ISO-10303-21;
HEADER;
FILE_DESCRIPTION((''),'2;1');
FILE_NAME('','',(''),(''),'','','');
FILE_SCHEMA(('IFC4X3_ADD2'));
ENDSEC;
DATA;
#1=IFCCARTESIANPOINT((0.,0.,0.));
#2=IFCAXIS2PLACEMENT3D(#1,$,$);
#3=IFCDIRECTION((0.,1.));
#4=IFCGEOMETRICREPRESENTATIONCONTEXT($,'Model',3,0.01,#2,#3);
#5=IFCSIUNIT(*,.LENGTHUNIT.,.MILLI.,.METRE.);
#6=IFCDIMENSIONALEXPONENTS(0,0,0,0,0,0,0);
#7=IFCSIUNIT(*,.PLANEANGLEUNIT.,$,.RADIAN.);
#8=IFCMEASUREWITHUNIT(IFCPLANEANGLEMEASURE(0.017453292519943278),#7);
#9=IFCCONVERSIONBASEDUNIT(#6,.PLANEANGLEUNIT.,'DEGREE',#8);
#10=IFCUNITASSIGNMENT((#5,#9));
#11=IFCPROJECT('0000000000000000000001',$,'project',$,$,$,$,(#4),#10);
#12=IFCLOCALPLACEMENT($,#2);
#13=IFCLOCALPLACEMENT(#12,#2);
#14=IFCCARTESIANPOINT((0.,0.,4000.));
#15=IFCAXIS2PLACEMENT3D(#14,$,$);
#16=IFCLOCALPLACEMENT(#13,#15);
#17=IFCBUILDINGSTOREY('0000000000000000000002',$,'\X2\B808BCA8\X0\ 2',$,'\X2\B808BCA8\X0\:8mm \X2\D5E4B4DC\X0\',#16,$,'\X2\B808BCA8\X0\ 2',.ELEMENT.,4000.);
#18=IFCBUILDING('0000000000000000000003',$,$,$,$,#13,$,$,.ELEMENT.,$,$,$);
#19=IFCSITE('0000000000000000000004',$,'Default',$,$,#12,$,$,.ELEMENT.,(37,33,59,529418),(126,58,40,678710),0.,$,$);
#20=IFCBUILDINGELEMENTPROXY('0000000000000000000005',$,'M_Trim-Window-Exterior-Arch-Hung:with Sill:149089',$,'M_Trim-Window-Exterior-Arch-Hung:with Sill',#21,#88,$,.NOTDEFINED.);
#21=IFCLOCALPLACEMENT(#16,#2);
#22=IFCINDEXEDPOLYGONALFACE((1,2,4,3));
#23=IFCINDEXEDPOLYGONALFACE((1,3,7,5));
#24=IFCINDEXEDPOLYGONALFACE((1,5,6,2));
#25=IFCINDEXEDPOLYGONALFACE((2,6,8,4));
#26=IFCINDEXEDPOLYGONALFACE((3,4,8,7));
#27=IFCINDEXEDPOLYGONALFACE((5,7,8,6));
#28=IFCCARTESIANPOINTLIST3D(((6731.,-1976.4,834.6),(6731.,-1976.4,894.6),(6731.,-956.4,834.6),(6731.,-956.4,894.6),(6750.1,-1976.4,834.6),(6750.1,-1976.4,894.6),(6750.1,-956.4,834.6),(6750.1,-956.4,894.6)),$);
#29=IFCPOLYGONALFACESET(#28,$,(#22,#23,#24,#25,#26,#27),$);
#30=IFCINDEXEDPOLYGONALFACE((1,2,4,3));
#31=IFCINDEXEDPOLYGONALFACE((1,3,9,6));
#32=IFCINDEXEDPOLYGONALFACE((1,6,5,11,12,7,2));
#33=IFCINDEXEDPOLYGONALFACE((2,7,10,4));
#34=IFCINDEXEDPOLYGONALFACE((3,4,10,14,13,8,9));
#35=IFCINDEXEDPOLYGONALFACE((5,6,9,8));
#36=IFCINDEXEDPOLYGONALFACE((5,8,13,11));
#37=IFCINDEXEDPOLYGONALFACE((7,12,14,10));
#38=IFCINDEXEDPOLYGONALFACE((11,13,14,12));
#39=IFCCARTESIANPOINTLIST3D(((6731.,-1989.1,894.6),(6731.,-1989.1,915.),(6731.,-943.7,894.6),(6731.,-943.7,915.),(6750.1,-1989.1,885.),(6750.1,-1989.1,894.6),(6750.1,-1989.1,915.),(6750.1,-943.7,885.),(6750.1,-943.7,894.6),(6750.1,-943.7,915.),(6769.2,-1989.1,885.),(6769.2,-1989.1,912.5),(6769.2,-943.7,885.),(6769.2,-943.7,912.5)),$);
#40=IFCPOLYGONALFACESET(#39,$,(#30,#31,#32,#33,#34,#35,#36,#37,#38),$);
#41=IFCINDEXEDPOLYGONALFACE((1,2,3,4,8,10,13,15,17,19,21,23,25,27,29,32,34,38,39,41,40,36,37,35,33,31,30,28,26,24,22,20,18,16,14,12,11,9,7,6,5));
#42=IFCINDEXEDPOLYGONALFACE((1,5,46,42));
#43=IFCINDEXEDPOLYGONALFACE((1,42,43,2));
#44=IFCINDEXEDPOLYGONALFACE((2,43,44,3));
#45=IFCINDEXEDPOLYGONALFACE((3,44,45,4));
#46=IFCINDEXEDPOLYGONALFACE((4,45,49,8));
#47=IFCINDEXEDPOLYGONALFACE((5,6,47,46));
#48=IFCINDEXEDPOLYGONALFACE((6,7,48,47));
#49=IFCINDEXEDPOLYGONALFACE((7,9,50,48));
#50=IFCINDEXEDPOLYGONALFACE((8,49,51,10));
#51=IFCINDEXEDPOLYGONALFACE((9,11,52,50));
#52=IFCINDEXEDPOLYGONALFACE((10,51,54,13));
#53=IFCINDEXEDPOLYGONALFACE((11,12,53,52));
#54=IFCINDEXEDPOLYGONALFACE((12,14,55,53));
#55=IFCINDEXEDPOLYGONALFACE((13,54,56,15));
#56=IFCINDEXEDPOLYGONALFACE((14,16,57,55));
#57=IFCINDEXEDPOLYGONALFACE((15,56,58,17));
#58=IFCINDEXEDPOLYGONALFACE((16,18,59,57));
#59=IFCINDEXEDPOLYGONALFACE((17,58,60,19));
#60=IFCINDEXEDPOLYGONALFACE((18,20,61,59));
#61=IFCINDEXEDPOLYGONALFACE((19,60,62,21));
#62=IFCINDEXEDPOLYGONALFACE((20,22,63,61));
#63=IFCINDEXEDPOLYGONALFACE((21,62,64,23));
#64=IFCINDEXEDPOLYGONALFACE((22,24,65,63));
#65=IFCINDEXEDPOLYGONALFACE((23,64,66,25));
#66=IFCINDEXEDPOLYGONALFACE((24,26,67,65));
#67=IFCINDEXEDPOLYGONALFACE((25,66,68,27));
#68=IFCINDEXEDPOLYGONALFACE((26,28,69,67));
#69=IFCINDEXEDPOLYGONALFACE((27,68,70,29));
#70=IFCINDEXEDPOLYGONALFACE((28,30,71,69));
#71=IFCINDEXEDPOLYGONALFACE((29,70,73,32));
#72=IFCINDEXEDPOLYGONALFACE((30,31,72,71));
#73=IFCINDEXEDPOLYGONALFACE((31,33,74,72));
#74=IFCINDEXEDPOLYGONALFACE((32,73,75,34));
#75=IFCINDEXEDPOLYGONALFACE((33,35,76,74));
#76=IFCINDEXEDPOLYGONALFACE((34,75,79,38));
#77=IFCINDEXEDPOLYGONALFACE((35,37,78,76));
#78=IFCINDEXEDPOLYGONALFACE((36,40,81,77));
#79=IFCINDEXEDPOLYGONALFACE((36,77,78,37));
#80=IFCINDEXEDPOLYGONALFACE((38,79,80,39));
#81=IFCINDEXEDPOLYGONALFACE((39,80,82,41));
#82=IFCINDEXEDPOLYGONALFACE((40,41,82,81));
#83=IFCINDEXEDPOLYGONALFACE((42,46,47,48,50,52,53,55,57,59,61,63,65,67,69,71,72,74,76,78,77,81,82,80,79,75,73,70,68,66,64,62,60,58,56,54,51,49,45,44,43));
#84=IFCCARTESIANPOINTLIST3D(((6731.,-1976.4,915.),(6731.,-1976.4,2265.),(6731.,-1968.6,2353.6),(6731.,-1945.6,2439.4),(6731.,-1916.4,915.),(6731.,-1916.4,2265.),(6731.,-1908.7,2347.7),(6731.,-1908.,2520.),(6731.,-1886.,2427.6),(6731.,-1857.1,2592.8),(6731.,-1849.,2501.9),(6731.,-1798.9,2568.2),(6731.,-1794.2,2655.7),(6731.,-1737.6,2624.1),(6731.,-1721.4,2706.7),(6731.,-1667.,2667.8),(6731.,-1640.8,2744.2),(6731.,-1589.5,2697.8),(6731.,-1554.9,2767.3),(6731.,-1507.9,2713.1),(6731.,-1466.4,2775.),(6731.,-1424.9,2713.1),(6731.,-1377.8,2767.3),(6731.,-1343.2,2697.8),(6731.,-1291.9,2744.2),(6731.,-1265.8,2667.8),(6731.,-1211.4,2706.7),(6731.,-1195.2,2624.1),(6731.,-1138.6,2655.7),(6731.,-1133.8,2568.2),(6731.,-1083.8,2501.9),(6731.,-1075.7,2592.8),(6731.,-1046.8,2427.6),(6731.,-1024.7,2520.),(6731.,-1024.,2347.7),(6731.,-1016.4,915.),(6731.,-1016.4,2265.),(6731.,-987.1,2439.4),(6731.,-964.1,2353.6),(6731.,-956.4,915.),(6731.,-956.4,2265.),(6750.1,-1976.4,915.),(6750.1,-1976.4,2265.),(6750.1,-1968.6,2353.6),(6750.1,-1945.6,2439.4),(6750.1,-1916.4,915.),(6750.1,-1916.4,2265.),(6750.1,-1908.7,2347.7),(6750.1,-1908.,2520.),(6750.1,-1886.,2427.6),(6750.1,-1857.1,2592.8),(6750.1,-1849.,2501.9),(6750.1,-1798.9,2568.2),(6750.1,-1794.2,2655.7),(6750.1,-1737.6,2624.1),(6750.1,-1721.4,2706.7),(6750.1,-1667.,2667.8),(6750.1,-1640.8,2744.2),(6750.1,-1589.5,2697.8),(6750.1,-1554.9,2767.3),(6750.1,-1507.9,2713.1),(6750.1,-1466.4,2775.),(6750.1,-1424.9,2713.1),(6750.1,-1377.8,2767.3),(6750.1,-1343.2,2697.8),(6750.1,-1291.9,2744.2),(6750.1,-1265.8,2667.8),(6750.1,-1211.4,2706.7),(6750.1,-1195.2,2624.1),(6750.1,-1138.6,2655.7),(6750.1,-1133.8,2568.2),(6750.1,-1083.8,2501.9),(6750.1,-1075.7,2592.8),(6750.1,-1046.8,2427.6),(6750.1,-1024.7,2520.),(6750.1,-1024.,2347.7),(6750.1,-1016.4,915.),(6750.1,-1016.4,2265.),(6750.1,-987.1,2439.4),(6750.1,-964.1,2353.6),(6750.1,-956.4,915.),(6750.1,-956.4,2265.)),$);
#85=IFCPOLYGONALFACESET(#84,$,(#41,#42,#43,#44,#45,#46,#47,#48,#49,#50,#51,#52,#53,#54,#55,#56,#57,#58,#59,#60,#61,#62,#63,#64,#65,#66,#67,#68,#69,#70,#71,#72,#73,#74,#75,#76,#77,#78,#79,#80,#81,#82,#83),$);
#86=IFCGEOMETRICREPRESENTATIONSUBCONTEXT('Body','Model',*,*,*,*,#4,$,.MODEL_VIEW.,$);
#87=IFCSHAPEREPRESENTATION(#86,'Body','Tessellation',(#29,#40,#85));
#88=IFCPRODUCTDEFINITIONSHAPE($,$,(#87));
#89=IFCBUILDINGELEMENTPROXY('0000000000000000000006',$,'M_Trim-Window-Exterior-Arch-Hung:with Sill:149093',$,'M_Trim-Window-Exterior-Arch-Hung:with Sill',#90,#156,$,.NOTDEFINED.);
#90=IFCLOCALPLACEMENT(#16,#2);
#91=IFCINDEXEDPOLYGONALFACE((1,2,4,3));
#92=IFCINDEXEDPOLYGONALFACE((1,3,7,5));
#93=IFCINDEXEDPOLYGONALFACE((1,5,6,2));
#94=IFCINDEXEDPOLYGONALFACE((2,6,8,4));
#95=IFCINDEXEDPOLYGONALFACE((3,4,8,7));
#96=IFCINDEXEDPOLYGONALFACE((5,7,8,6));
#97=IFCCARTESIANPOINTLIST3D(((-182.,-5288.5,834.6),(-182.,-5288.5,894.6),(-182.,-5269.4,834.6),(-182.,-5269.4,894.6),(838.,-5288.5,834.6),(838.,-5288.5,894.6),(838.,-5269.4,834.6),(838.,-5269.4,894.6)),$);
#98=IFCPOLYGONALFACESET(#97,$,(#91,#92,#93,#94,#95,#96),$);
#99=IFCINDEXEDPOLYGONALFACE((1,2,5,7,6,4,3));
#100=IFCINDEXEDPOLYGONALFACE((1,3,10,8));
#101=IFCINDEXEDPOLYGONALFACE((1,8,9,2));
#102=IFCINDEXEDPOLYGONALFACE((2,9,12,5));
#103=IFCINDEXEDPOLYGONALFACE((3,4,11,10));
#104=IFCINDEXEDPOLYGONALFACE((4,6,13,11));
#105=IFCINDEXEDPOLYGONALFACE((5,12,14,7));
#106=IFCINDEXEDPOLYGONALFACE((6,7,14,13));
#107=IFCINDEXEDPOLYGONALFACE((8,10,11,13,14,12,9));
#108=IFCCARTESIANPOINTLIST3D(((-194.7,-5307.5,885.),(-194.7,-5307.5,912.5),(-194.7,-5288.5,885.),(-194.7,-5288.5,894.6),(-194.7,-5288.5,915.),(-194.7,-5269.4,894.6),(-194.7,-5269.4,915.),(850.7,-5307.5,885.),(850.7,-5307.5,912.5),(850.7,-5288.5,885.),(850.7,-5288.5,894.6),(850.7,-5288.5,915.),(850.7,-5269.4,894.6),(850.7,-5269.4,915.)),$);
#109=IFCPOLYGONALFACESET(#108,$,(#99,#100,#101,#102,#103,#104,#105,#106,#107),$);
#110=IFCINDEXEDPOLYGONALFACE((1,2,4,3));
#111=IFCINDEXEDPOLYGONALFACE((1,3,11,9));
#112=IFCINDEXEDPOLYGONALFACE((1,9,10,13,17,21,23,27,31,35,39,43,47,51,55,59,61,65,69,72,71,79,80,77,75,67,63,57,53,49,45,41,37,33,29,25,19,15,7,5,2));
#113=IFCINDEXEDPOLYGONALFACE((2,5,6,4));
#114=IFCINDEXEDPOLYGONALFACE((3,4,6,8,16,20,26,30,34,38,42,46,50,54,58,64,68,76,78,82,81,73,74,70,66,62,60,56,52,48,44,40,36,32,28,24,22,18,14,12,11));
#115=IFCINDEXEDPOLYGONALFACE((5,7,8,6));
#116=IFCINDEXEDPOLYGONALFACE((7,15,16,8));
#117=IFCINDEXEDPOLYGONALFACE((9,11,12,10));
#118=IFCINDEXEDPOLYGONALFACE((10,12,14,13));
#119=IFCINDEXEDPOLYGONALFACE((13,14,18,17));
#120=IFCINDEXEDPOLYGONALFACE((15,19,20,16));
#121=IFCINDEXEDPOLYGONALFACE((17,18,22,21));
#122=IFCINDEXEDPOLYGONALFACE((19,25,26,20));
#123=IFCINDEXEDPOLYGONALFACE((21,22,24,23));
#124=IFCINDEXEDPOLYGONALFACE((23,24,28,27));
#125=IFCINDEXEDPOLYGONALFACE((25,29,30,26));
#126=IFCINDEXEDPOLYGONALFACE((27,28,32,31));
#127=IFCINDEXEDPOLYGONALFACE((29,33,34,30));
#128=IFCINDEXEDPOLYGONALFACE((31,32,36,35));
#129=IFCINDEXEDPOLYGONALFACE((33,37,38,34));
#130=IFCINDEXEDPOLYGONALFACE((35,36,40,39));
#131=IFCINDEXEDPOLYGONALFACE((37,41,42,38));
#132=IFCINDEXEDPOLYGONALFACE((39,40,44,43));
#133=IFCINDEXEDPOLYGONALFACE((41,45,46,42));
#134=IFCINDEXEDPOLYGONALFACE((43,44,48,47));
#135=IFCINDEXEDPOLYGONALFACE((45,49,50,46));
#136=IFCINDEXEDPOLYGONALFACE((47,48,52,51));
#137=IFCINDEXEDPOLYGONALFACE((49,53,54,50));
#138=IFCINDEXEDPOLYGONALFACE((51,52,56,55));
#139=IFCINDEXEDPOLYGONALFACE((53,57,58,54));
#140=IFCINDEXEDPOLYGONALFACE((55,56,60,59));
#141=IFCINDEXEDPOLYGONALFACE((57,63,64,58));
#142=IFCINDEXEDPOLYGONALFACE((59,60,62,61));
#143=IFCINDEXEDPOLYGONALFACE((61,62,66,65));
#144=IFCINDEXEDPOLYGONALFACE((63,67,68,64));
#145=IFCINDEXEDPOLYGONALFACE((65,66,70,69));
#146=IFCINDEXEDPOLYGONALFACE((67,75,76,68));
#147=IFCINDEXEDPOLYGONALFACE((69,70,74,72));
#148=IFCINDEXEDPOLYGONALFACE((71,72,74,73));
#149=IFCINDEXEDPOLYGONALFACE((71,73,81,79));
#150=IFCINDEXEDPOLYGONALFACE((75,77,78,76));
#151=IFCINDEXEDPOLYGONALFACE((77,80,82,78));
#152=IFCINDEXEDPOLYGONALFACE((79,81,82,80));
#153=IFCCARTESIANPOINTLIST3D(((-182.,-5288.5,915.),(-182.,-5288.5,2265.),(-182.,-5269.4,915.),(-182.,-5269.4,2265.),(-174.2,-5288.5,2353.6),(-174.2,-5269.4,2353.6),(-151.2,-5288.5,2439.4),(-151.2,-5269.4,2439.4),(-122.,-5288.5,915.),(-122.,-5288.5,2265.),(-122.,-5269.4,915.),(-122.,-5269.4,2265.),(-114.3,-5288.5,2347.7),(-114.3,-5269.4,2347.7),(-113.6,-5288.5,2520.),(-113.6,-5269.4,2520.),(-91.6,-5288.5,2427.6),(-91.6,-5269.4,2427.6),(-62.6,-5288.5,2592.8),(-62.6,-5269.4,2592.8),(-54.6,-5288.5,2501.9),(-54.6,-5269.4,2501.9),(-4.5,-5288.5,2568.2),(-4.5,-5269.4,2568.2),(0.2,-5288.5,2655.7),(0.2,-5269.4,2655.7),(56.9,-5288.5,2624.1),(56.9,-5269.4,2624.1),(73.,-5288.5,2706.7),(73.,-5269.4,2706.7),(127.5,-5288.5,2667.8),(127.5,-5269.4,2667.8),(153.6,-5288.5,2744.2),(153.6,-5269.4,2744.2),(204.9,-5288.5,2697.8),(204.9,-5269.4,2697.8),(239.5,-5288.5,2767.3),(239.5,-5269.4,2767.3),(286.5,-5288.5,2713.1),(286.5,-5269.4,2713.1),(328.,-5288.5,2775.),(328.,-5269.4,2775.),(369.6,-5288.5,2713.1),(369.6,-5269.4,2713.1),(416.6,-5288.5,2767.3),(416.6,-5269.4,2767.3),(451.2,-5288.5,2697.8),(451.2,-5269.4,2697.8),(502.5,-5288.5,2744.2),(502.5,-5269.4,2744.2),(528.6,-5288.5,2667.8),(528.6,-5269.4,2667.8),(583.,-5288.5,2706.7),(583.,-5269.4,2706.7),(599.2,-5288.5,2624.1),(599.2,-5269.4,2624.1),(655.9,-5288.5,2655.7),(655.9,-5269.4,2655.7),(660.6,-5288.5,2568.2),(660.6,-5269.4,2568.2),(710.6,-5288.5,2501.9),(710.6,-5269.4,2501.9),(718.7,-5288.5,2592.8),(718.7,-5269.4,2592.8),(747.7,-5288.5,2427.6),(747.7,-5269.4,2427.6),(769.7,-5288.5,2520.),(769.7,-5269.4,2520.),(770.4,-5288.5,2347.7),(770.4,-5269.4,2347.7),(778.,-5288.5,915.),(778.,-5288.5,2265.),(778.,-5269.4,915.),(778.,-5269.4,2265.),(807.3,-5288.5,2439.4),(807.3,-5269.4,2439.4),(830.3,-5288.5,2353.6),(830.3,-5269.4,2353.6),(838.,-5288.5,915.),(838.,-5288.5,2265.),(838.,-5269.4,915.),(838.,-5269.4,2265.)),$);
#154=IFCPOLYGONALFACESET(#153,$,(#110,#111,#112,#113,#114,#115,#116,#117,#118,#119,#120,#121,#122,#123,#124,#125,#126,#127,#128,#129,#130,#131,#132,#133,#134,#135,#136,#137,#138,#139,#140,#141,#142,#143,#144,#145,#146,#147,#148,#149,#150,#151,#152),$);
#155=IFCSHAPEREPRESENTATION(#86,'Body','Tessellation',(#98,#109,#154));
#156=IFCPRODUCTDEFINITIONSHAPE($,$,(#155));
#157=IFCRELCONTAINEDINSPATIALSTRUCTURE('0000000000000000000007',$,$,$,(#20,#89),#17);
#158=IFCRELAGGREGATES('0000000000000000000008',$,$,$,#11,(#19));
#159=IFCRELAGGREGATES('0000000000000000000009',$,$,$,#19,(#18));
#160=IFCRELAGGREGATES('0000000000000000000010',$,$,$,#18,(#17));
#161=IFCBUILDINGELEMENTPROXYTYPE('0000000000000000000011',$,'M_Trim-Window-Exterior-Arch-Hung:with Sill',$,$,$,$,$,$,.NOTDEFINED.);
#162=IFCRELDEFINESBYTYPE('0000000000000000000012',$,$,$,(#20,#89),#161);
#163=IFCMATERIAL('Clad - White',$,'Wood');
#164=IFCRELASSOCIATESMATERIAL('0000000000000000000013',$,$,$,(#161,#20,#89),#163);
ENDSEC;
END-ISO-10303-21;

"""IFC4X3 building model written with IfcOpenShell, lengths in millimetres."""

from ifc_helpers import new_model, entity, si_unit, converted_unit, direction, frame, frame_2d, origin, place, context, subcontext, project, spatial, polyline, circle_curve, parameter, trimmed, segment, composite_curve, rectangle, outline, extrude, source, transform, mapped, material, type_object, type_shapes, element, save


model = new_model("IFC4X3")

# Units and contexts
model_context = context("Model", 3, precision=0.01, world=origin(), true_north=direction((0.0, 1.0)))
body_context = subcontext(model_context, "Body", "Model", "MODEL_VIEW")
ifc_project = project(units=[si_unit("LENGTHUNIT", "METRE", prefix="MILLI"), converted_unit("PLANEANGLEUNIT", "DEGREE", entity("IfcPlaneAngleMeasure", 0.017453292519943278), si_unit("PLANEANGLEUNIT", "RADIAN"), dimensions=[0, 0, 0, 0, 0, 0, 0])], contexts=[model_context])

# Site, building, storey
site_placement = place(None, origin())
site = spatial("IfcSite", under=ifc_project, at=site_placement, Name="Default", CompositionType="ELEMENT", RefLatitude=(37, 33, 59, 529418), RefLongitude=(126, 58, 40, 678710), RefElevation=0.0)
building_placement = place(site_placement, origin())
building = spatial("IfcBuilding", under=site, at=building_placement, CompositionType="ELEMENT")
storey_placement = place(building_placement, frame((0.0, 0.0, 4000.0)))
storey = spatial("IfcBuildingStorey", under=building, at=storey_placement, Name="레벨 2", ObjectType="레벨:8mm 헤드", LongName="레벨 2", CompositionType="ELEMENT", Elevation=4000.0)

# Building element proxies
ifc_material_1 = material(Name="Clad - White", Category="Wood")
building_element_proxy_type_1 = type_object("IfcBuildingElementProxyType", Name="M_Trim-Window-Exterior-Arch-Hung:with Sill", PredefinedType="NOTDEFINED", material=ifc_material_1)
shared_shape_1 = source(origin(), body_context, "Body", "SweptSolid", [
    extrude(rectangle(XDim=1020.0, YDim=60.0, at=frame_2d((0.0, 0.0), x_axis=(1.0, 0.0))), frame((0.0, -1850.4, 0.0), z_axis=(0.0, 0.0, 1.0), x_axis=(-1.0, 0.0, 0.0)), (0.0, 0.0, 1.0), 19.1),
    extrude(outline(polyline([(-19.1, -15.2), (0.0, -15.2), (0.0, -5.7), (19.1, -5.7), (19.1, 14.8), (0.0, 14.8), (-19.1, 12.3), (-19.1, -15.2)])), frame((-522.7, -1814.8, 19.1), z_axis=(1.0, 0.0, 0.0), x_axis=(0.0, 0.0, -1.0)), (0.0, 0.0, 1.0), 1045.4),
    extrude(outline(composite_curve([segment(polyline([(-675.0, -510.0), (675.0, -510.0)]), True, "CONTINUOUS"), segment(polyline([(675.0, -510.0), (675.0, -450.0)]), True, "CONTINUOUS"), segment(polyline([(675.0, -450.0), (-675.0, -450.0)]), True, "CONTINUOUS"), segment(trimmed(circle_curve(frame_2d((-675.0, 0.0), x_axis=(0.0, 1.0)), 450.0), [parameter(0.0)], [parameter(180.0)], True, "PARAMETER"), False, "CONTINUOUS"), segment(polyline([(-675.0, 450.0), (675.0, 450.0)]), True, "CONTINUOUS"), segment(polyline([(675.0, 450.0), (675.0, 510.0)]), True, "CONTINUOUS"), segment(polyline([(675.0, 510.0), (-675.0, 510.0)]), True, "CONTINUOUS"), segment(trimmed(circle_curve(frame_2d((-675.0, 0.0), x_axis=(0.0, 1.0)), 510.0), [parameter(0.0)], [parameter(180.0)], True, "PARAMETER"), True, "CONTINUOUS")], self_intersect=False)), frame((0.0, -1125.0, 0.0), z_axis=(0.0, 0.0, 1.0), x_axis=(0.0, -1.0, 0.0)), (0.0, 0.0, 1.0), 19.1),
])
type_shapes(building_element_proxy_type_1, [shared_shape_1])
for number, where, z_axis, x_axis, name in (
    (1, (6731.0, -1466.4, 2715.0), (1.0, 0.0, 0.0), (0.0, 1.0, 0.0), "M_Trim-Window-Exterior-Arch-Hung:with Sill:149089"),
    (2, (328.0, -5269.4, 2715.0), (0.0, -1.0, 0.0), (1.0, 0.0, 0.0), "M_Trim-Window-Exterior-Arch-Hung:with Sill:149093"),
):
    element("IfcBuildingElementProxy", number, at=place(storey_placement, frame(where, z_axis=z_axis, x_axis=x_axis)), inside=storey, type_object=building_element_proxy_type_1, material=ifc_material_1, Name=name, ObjectType="M_Trim-Window-Exterior-Arch-Hung:with Sill", PredefinedType="NOTDEFINED", context=body_context, shape_type="MappedRepresentation", body=[
        mapped(shared_shape_1, transform((0.0, 0.0, 0.0), scale=1.0)),
    ])

save(model, "model.ifc")
